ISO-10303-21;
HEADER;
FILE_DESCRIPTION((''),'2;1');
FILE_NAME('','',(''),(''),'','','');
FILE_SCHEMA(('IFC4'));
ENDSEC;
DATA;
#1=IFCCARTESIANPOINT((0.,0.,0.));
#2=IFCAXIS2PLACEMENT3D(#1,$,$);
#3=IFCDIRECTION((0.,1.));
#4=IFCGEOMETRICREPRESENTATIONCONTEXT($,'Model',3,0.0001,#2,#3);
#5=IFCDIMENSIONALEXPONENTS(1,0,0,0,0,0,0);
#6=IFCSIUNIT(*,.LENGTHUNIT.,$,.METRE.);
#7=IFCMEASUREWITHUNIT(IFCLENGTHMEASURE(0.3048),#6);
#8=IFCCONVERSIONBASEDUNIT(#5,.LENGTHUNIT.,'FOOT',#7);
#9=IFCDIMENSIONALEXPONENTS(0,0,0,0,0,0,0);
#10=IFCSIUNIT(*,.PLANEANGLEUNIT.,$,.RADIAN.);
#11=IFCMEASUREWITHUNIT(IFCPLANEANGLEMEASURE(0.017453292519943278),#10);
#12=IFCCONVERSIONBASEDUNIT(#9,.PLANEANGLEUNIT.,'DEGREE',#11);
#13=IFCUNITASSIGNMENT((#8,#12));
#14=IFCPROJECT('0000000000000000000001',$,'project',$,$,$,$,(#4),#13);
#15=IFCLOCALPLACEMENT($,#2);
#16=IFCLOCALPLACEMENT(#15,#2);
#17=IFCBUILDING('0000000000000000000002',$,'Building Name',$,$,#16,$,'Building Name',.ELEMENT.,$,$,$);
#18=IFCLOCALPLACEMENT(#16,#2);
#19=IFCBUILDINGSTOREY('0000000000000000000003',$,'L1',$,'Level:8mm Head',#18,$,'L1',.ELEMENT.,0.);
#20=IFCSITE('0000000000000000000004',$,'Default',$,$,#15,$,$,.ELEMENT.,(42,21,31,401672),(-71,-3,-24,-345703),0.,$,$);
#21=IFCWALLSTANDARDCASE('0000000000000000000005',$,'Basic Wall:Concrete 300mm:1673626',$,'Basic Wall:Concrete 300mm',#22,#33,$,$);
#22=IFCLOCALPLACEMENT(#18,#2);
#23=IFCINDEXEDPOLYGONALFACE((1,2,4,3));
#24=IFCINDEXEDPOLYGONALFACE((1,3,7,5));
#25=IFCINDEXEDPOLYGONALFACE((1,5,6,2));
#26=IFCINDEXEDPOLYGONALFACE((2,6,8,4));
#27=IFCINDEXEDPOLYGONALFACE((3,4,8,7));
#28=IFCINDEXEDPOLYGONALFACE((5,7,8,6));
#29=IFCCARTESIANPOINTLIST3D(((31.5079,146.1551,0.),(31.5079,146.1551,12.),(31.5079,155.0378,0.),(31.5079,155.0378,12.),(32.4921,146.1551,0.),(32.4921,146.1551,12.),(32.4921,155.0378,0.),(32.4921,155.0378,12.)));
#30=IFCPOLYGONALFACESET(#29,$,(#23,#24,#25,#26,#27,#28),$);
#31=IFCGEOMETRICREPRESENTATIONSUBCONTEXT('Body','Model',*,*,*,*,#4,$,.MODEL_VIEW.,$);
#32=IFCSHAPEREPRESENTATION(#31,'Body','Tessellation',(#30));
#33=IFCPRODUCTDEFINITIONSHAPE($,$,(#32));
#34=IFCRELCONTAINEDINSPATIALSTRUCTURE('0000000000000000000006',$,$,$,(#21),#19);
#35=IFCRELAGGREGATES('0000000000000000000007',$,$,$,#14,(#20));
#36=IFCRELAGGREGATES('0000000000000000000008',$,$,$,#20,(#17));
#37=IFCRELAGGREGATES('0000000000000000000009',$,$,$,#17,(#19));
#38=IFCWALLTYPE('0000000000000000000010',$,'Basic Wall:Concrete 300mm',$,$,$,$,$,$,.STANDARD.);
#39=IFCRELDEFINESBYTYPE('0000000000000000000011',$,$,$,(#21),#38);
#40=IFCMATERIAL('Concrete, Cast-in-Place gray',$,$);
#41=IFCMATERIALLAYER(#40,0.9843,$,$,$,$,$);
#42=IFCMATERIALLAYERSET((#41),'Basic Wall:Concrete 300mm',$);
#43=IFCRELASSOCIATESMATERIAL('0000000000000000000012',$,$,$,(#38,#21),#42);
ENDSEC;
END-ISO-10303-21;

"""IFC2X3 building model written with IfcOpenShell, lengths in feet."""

from ifc_helpers import new_model, entity, si_unit, converted_unit, direction, frame, frame_2d, origin, place, context, subcontext, project, spatial, rectangle, extrude, material, layer, layer_set, layer_usage, type_object, element, save


model = new_model("IFC2X3")

# Units and contexts
model_context = context("Model", 3, precision=0.0001, world=origin(), true_north=direction((0.0, 1.0)))
body_context = subcontext(model_context, "Body", "Model", "MODEL_VIEW")
ifc_project = project(units=[converted_unit("LENGTHUNIT", "FOOT", entity("IfcLengthMeasure", 0.3048), si_unit("LENGTHUNIT", "METRE"), dimensions=[1, 0, 0, 0, 0, 0, 0]), converted_unit("PLANEANGLEUNIT", "DEGREE", entity("IfcPlaneAngleMeasure", 0.017453292519943278), si_unit("PLANEANGLEUNIT", "RADIAN"), dimensions=[0, 0, 0, 0, 0, 0, 0])], contexts=[model_context])

# Site, building, storey
site_placement = place(None, origin())
site = spatial("IfcSite", under=ifc_project, at=site_placement, Name="Default", CompositionType="ELEMENT", RefLatitude=(42, 21, 31, 401672), RefLongitude=(-71, -3, -24, -345703), RefElevation=0.0)
building_placement = place(site_placement, origin())
building = spatial("IfcBuilding", under=site, at=building_placement, Name="Building Name", LongName="Building Name", CompositionType="ELEMENT")
storey_placement = place(building_placement, origin())
storey = spatial("IfcBuildingStorey", under=building, at=storey_placement, Name="L1", ObjectType="Level:8mm Head", LongName="L1", CompositionType="ELEMENT", Elevation=0.0)

# Shared definitions
ifc_material_1 = material(Name="Concrete, Cast-in-Place gray")
ifc_layer = layer(ifc_material_1, 0.9843)
ifc_layer_set = layer_set([ifc_layer], Name="Basic Wall:Concrete 300mm")
wall_type = type_object("IfcWallType", Name="Basic Wall:Concrete 300mm", PredefinedType="STANDARD", material=ifc_layer_set)

# Wall
ifc_layer_usage_1 = layer_usage(ifc_layer_set, "AXIS2", "NEGATIVE", 0.4921)
wall_1_placement = place(storey_placement, frame((32.0, 155.0378, 0.0), z_axis=(0.0, 0.0, 1.0), x_axis=(0.0, -1.0, 0.0)))
element("IfcWallStandardCase", 1, at=wall_1_placement, inside=storey, type_object=wall_type, material=ifc_layer_usage_1, Name="Basic Wall:Concrete 300mm:1673626", ObjectType="Basic Wall:Concrete 300mm", context=body_context, shape_type="SweptSolid", body=[
    extrude(rectangle(XDim=8.8827, YDim=0.9843, at=frame_2d((4.4414, 0.0), x_axis=(-1.0, 0.0))), origin(), (0.0, 0.0, 1.0), 12.0),
])

save(model, "model.ifc")
